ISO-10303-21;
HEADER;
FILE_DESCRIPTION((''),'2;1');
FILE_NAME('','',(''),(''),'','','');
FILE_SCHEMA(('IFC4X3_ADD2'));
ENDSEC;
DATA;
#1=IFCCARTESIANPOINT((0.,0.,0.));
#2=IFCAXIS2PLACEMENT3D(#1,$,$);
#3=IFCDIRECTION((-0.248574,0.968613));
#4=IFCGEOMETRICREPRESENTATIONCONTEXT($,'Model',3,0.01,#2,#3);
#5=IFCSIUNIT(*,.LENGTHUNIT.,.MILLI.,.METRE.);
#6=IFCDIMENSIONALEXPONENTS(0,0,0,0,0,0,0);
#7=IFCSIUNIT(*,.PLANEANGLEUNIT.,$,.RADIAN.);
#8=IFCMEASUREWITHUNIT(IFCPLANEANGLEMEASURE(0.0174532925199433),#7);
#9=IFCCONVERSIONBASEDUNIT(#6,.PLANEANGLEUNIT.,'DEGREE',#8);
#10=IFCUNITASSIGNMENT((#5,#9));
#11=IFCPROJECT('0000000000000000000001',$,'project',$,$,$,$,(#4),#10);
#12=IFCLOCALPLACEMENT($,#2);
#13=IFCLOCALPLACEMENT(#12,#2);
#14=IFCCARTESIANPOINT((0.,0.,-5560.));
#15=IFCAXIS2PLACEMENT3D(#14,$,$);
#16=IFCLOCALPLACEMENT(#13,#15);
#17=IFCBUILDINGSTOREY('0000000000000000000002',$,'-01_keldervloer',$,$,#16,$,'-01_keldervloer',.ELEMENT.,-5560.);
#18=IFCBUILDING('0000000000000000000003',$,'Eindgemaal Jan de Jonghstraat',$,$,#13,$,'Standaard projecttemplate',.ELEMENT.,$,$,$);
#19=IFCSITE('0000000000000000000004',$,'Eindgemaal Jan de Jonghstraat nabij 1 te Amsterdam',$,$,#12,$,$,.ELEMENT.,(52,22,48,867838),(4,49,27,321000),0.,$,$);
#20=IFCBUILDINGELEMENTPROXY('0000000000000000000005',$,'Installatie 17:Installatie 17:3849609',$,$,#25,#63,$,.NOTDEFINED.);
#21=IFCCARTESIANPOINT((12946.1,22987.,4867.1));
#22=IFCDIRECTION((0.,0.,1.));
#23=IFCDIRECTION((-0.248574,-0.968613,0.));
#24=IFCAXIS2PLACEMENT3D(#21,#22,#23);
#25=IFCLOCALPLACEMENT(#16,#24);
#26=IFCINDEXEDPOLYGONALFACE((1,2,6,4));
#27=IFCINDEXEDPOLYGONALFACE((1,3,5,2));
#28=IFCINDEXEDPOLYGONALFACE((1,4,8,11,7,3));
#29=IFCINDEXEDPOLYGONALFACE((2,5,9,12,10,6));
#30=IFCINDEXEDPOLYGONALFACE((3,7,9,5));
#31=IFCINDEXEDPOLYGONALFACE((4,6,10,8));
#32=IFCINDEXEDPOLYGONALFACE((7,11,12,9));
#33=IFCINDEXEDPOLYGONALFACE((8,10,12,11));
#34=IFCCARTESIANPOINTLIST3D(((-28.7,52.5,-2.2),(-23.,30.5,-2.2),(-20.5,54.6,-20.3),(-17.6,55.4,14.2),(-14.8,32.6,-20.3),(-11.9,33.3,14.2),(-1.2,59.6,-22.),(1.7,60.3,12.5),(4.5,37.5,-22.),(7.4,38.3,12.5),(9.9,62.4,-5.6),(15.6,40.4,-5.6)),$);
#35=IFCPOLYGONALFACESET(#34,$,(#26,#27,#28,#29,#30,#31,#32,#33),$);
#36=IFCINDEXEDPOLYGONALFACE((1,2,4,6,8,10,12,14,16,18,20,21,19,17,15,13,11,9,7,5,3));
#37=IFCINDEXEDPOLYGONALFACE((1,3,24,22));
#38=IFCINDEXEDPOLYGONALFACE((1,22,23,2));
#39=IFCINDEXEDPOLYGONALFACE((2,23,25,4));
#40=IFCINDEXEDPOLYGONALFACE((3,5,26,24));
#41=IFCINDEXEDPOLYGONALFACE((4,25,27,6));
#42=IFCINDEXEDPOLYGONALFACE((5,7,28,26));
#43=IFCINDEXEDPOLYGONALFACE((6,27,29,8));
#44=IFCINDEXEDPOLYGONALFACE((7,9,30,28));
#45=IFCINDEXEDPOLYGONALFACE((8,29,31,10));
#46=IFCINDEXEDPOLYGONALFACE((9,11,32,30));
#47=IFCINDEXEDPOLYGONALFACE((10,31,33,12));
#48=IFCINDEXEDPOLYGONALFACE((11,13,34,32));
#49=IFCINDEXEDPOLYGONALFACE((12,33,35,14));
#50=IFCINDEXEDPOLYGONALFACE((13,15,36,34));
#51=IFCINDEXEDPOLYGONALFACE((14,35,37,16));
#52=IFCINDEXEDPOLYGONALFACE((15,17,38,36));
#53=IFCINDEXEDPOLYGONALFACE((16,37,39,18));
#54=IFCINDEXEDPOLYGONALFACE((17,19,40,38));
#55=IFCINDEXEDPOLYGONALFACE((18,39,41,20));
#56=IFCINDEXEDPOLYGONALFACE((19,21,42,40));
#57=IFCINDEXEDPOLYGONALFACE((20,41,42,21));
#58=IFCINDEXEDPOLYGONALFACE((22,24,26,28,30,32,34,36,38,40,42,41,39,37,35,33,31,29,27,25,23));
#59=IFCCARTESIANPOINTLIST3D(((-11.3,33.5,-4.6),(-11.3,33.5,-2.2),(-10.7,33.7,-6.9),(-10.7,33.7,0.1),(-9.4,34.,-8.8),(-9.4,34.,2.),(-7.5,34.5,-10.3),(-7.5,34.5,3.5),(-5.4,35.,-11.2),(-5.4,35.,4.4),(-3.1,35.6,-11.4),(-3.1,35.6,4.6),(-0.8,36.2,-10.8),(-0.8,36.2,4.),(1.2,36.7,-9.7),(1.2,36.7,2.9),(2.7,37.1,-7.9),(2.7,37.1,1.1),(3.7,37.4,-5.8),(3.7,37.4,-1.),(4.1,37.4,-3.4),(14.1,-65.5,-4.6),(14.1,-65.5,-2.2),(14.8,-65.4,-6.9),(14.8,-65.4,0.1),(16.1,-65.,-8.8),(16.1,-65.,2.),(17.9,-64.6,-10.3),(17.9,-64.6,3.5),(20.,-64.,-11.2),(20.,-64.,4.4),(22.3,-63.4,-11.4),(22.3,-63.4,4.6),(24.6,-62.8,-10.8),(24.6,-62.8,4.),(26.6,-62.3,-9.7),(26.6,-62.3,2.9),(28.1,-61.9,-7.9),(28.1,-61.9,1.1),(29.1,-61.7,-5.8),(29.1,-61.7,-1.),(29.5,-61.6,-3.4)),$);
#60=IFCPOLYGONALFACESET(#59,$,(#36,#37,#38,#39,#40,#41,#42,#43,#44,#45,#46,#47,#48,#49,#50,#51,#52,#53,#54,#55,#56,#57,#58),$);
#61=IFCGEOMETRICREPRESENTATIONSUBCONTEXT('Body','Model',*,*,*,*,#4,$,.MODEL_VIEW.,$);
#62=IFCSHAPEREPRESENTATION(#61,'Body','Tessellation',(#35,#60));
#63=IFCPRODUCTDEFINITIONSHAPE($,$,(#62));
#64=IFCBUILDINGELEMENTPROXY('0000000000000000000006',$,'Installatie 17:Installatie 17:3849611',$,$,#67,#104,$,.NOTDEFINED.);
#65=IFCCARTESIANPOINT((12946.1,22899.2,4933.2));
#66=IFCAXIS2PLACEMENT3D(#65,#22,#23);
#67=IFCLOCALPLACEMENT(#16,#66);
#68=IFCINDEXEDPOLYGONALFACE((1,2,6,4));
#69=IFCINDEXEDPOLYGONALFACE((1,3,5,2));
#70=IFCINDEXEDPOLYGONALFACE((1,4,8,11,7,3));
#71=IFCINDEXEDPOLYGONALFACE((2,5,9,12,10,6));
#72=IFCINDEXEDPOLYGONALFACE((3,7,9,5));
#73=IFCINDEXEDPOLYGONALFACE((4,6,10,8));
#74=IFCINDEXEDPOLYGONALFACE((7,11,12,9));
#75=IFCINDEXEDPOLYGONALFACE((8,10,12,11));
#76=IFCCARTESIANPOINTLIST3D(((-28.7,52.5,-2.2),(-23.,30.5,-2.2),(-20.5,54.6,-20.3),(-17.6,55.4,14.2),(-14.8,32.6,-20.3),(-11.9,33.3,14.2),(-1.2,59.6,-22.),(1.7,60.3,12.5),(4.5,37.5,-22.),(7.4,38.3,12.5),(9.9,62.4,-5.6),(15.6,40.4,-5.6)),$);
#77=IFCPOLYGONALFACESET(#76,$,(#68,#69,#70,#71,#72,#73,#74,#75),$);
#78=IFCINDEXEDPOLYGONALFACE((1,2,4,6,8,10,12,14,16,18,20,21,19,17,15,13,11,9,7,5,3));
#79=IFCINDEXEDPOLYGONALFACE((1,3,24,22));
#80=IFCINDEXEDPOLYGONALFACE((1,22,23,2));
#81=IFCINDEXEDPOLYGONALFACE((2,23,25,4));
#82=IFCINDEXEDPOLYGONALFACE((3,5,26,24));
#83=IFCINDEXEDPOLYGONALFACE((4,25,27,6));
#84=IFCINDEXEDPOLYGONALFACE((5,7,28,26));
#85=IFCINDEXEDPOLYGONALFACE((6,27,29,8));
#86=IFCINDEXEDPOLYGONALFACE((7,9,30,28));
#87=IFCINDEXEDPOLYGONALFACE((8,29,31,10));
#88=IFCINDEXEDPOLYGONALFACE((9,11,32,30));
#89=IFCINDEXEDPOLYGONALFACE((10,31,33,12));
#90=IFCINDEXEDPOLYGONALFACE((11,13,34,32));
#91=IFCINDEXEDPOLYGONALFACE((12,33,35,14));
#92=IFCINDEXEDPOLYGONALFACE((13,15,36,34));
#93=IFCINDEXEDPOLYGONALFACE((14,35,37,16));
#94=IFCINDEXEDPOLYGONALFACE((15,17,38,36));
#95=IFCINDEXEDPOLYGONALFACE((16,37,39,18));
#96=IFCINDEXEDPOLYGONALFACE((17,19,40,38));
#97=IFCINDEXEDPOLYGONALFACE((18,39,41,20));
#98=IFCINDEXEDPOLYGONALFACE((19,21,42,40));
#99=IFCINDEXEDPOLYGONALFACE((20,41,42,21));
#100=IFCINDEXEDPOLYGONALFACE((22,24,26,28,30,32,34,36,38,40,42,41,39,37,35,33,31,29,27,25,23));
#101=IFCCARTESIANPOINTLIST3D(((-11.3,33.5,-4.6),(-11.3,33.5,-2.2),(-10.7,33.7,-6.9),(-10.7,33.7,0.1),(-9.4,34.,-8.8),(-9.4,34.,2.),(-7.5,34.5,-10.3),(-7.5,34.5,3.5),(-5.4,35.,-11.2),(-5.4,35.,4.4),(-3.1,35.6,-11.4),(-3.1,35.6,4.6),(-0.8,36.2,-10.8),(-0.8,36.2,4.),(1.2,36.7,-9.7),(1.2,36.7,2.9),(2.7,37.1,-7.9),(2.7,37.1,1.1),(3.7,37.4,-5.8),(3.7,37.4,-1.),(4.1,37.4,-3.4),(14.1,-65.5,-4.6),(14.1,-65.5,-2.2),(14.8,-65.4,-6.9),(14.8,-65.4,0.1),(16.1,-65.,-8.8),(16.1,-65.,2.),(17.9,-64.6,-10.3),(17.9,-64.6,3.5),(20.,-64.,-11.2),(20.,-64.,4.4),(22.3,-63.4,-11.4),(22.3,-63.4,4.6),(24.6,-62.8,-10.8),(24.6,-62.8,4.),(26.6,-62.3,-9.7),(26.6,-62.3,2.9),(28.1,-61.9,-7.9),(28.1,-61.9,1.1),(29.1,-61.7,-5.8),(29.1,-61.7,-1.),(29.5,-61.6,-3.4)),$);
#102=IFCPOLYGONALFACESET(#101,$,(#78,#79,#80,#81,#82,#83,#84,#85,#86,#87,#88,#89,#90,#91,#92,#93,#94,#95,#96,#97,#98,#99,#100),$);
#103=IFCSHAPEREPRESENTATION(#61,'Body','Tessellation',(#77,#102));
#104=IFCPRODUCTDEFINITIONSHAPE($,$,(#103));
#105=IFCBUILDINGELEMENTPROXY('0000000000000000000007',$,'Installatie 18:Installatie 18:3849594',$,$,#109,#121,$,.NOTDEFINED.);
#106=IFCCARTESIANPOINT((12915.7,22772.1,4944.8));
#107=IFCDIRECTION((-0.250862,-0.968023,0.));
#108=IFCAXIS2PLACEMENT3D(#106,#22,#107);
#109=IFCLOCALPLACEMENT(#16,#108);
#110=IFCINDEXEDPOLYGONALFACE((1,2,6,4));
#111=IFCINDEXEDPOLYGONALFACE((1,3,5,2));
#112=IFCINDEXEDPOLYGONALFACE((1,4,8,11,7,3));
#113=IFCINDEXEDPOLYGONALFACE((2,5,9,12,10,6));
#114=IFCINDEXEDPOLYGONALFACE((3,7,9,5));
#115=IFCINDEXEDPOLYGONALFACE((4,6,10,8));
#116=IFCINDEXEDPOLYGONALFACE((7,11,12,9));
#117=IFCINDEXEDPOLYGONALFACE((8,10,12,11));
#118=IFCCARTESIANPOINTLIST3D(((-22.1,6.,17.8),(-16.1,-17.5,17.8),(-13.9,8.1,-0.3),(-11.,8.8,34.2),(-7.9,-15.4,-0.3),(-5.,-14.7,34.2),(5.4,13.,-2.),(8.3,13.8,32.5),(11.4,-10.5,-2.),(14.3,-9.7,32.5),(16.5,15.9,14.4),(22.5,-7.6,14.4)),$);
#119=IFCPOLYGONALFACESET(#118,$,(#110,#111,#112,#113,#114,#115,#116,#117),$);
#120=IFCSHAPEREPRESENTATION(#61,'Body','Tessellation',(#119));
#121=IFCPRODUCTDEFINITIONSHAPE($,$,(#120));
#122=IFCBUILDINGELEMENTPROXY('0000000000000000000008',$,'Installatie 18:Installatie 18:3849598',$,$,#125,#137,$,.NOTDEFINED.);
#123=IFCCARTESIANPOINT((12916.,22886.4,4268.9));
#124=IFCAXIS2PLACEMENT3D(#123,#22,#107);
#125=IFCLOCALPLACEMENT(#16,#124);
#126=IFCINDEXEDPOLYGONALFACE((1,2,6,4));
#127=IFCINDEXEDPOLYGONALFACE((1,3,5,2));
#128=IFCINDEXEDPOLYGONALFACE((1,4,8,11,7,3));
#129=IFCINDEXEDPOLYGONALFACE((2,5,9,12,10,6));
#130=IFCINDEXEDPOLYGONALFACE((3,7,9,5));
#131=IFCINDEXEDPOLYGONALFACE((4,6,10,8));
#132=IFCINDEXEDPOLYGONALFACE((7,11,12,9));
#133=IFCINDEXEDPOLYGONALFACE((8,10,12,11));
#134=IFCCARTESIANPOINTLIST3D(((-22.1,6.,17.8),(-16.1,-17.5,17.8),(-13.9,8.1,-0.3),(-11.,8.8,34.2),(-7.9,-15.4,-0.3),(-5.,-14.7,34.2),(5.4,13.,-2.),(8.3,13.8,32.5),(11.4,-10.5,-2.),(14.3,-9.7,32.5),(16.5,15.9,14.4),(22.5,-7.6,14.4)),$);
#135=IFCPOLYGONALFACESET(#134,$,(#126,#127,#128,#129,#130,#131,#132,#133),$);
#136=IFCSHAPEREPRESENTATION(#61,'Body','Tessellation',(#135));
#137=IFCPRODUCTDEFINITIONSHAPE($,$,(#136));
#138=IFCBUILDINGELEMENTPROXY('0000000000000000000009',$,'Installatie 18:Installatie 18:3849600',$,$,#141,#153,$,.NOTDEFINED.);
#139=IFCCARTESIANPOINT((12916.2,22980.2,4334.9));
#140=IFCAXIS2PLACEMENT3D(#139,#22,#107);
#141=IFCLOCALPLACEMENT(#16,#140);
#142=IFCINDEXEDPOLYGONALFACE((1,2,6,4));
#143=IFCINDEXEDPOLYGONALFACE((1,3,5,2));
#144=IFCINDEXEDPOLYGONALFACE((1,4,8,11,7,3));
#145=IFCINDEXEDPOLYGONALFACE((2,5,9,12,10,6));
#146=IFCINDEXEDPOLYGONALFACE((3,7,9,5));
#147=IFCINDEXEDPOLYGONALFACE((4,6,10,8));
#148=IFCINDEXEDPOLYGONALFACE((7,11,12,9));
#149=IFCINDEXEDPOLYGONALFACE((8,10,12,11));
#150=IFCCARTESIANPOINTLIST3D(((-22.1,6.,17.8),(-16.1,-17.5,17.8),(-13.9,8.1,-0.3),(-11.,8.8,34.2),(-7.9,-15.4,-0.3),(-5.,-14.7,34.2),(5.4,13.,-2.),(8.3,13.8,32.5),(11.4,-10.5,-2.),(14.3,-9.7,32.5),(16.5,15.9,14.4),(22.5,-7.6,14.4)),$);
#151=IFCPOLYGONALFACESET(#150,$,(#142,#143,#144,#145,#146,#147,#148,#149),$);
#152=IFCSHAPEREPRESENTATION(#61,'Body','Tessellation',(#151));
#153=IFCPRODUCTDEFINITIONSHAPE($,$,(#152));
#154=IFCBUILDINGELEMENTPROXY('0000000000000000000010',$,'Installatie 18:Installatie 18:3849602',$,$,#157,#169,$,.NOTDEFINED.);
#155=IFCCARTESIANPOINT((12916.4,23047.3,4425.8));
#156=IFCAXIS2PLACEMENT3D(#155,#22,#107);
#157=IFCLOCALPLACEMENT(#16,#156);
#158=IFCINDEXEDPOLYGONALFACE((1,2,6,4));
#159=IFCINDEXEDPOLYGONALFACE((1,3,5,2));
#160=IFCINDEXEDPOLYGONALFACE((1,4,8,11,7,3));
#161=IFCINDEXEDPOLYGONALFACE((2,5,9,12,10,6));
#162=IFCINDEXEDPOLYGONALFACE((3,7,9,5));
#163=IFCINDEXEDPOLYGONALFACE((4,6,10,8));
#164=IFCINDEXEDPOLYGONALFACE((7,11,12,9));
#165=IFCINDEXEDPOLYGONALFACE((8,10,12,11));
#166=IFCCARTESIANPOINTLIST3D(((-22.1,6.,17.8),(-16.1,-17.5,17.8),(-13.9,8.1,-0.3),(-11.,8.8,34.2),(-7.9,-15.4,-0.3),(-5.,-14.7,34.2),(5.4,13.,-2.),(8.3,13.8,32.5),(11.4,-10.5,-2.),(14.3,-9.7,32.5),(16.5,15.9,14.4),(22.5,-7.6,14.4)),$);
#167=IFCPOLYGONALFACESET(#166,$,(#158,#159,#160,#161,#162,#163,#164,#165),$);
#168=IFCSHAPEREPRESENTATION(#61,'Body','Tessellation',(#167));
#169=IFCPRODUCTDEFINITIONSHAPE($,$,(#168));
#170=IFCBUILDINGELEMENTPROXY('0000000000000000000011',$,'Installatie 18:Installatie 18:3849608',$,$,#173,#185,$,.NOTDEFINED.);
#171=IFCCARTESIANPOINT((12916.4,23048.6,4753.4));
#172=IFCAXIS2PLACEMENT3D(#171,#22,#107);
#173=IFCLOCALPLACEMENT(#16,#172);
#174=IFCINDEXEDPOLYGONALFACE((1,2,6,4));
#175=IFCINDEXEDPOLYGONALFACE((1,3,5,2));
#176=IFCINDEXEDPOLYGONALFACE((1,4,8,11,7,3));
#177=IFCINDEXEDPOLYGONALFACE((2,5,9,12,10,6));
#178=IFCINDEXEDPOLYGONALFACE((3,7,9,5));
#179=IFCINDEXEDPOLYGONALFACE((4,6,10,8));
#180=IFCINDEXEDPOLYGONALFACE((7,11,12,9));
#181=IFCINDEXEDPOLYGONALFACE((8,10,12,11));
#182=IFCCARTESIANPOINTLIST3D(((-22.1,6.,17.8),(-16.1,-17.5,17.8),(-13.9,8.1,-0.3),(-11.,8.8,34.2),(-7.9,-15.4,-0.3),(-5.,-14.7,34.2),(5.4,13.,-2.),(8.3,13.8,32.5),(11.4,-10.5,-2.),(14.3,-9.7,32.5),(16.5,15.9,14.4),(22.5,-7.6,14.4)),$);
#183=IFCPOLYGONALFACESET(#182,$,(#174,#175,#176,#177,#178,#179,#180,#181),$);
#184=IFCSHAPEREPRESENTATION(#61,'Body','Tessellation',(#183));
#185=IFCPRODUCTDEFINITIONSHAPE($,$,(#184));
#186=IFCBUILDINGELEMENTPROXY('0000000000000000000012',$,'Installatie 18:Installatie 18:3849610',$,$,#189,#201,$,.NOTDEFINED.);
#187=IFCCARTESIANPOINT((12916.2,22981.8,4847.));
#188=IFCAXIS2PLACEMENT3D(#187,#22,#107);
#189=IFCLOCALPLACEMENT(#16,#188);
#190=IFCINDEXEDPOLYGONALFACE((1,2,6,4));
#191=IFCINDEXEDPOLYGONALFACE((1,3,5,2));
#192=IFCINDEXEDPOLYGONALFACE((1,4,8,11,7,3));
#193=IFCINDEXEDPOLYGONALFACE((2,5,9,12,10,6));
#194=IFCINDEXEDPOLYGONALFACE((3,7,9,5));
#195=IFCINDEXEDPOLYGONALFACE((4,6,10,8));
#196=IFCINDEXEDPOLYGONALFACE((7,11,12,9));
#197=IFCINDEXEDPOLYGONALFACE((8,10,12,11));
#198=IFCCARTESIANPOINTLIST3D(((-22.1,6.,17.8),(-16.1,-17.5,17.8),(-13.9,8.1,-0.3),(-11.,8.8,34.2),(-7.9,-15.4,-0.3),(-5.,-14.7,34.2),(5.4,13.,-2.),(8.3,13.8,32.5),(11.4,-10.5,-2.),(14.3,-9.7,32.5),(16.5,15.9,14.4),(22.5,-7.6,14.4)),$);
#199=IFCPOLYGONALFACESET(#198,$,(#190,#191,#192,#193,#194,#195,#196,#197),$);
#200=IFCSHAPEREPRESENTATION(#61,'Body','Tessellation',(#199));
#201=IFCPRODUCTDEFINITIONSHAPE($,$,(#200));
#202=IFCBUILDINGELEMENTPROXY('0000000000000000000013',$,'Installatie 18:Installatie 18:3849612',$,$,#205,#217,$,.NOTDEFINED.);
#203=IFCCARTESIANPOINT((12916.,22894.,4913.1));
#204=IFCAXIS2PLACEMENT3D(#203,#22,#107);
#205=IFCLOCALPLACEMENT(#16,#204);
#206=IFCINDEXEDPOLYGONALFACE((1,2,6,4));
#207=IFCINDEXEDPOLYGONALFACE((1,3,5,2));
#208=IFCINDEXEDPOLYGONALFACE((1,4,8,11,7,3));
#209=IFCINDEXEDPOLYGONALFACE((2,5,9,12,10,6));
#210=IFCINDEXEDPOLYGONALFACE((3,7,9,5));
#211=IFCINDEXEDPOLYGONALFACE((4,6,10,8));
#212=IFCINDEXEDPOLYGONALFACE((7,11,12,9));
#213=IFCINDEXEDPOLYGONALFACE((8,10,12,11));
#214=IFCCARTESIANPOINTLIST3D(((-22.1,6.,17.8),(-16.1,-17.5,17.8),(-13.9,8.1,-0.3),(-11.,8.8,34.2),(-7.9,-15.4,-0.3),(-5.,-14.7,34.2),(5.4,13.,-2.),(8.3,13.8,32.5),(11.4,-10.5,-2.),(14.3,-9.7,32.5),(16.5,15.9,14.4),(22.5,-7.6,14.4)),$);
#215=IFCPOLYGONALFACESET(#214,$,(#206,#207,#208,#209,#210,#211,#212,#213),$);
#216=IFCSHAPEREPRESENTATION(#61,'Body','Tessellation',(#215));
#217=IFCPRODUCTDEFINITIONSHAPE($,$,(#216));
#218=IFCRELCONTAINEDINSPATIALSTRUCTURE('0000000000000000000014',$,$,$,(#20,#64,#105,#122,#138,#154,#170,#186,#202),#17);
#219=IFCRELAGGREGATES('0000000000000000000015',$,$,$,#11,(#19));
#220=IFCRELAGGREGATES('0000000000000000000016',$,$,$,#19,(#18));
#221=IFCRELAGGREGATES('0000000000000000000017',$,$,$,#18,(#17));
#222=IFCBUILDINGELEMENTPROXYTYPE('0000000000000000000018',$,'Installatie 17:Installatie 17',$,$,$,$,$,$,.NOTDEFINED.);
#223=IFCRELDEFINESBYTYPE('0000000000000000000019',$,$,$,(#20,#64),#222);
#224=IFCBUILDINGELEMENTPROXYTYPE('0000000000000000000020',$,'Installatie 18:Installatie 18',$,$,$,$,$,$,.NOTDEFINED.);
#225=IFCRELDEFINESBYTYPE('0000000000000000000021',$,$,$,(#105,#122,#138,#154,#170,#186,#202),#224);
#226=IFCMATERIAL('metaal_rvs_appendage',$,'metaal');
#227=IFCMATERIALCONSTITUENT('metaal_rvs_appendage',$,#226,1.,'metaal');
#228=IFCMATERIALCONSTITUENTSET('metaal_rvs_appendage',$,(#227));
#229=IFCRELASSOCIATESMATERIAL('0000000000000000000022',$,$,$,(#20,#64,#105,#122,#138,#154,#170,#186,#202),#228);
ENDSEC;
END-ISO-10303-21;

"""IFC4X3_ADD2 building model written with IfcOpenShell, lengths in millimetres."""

from ifc_helpers import new_model, entity, si_unit, converted_unit, direction, frame, frame_2d, origin, place, context, subcontext, project, spatial, polyline, circle, outline, extrude, source, transform, mapped, material, constituent, constituent_set, type_object, type_shapes, element, save


model = new_model("IFC4X3_ADD2")

# Units and contexts
model_context = context("Model", 3, precision=0.01, world=origin(), true_north=direction((-0.248574, 0.968613)))
body_context = subcontext(model_context, "Body", "Model", "MODEL_VIEW")
ifc_project = project(units=[si_unit("LENGTHUNIT", "METRE", prefix="MILLI"), converted_unit("PLANEANGLEUNIT", "DEGREE", entity("IfcPlaneAngleMeasure", 0.0174532925199433), si_unit("PLANEANGLEUNIT", "RADIAN"), dimensions=[0, 0, 0, 0, 0, 0, 0])], contexts=[model_context])

# Site, building, storey
site_placement = place(None, origin())
site = spatial("IfcSite", under=ifc_project, at=site_placement, Name="Eindgemaal Jan de Jonghstraat nabij 1 te Amsterdam", CompositionType="ELEMENT", RefLatitude=(52, 22, 48, 867838), RefLongitude=(4, 49, 27, 321000), RefElevation=0.0)
building_placement = place(site_placement, origin())
building = spatial("IfcBuilding", under=site, at=building_placement, Name="Eindgemaal Jan de Jonghstraat", LongName="Standaard projecttemplate", CompositionType="ELEMENT")
storey_placement = place(building_placement, frame((0.0, 0.0, -5560.0)))
storey = spatial("IfcBuildingStorey", under=building, at=storey_placement, Name="-01_keldervloer", LongName="-01_keldervloer", CompositionType="ELEMENT", Elevation=-5560.0)

# Building element proxies
ifc_material_1 = material(Name="metaal_rvs_appendage", Category="metaal")
ifc_constituent_1 = constituent(ifc_material_1, Name="metaal_rvs_appendage", Category="metaal", fraction=1.0)
ifc_constituent_set_1 = constituent_set(constituents=[ifc_constituent_1], Name="metaal_rvs_appendage")
building_element_proxy_type_1 = type_object("IfcBuildingElementProxyType", Name="Installatie 17:Installatie 17", PredefinedType="NOTDEFINED")
shared_shape_1 = source(origin(), body_context, "Body", "SweptSolid", [
    extrude(outline(polyline([(-10.0, -17.3), (10.0, -17.3), (20.0, 0.0), (10.0, 17.3), (-10.0, 17.3), (-20.0, 0.0), (-10.0, -17.3)])), frame((-3.7, 35.4, -3.9), z_axis=(-0.248574, 0.968613, 0.0), x_axis=(-0.555573, -0.142576, -0.819152)), (0.0, 0.0, 1.0), 22.8),
    extrude(circle(Radius=8.0, at=frame_2d((0.0, 0.0), x_axis=(1.0, 0.0))), frame((21.7, -63.6, -3.4), z_axis=(-0.248574, 0.968613, 0.0), x_axis=(0.968613, 0.248574, 0.0)), (0.0, 0.0, 1.0), 102.2),
])
type_shapes(building_element_proxy_type_1, [shared_shape_1])
for number, where, z_axis, x_axis, name in (
    (1, (12946.1, 22987.0, 4867.1), (0.0, 0.0, 1.0), (-0.248574, -0.968613, 0.0), "Installatie 17:Installatie 17:3849609"),
    (2, (12946.1, 22899.2, 4933.2), (0.0, 0.0, 1.0), (-0.248574, -0.968613, 0.0), "Installatie 17:Installatie 17:3849611"),
):
    element("IfcBuildingElementProxy", number, at=place(storey_placement, frame(where, z_axis=z_axis, x_axis=x_axis)), inside=storey, type_object=building_element_proxy_type_1, material=ifc_constituent_set_1, Name=name, PredefinedType="NOTDEFINED", context=body_context, shape_type="MappedRepresentation", body=[
        mapped(shared_shape_1, transform((0.0, 0.0, 0.0), scale=1.0)),
    ])
building_element_proxy_type_2 = type_object("IfcBuildingElementProxyType", Name="Installatie 18:Installatie 18", PredefinedType="NOTDEFINED")
shared_shape_2 = source(origin(), body_context, "Body", "SweptSolid", [
    extrude(outline(polyline([(-10.0, -17.3), (10.0, -17.3), (20.0, 0.0), (10.0, 17.3), (-10.0, 17.3), (-20.0, 0.0), (-10.0, -17.3)])), frame((3.2, -12.6, 16.1), z_axis=(-0.248574, 0.968613, 0.0), x_axis=(0.409353, 0.105052, -0.906308)), (0.0, 0.0, 1.0), 24.3),
])
type_shapes(building_element_proxy_type_2, [shared_shape_2])
for number, where, z_axis, x_axis, name in (
    (3, (12915.7, 22772.1, 4944.8), (0.0, 0.0, 1.0), (-0.250862, -0.968023, 0.0), "Installatie 18:Installatie 18:3849594"),
    (4, (12916.0, 22886.4, 4268.9), (0.0, 0.0, 1.0), (-0.250862, -0.968023, 0.0), "Installatie 18:Installatie 18:3849598"),
    (5, (12916.2, 22980.2, 4334.9), (0.0, 0.0, 1.0), (-0.250862, -0.968023, 0.0), "Installatie 18:Installatie 18:3849600"),
    (6, (12916.4, 23047.3, 4425.8), (0.0, 0.0, 1.0), (-0.250862, -0.968023, 0.0), "Installatie 18:Installatie 18:3849602"),
    (7, (12916.4, 23048.6, 4753.4), (0.0, 0.0, 1.0), (-0.250862, -0.968023, 0.0), "Installatie 18:Installatie 18:3849608"),
    (8, (12916.2, 22981.8, 4847.0), (0.0, 0.0, 1.0), (-0.250862, -0.968023, 0.0), "Installatie 18:Installatie 18:3849610"),
    (9, (12916.0, 22894.0, 4913.1), (0.0, 0.0, 1.0), (-0.250862, -0.968023, 0.0), "Installatie 18:Installatie 18:3849612"),
):
    element("IfcBuildingElementProxy", number, at=place(storey_placement, frame(where, z_axis=z_axis, x_axis=x_axis)), inside=storey, type_object=building_element_proxy_type_2, material=ifc_constituent_set_1, Name=name, PredefinedType="NOTDEFINED", context=body_context, shape_type="MappedRepresentation", body=[
        mapped(shared_shape_2, transform((0.0, 0.0, 0.0), scale=1.0)),
    ])

save(model, "model.ifc")
